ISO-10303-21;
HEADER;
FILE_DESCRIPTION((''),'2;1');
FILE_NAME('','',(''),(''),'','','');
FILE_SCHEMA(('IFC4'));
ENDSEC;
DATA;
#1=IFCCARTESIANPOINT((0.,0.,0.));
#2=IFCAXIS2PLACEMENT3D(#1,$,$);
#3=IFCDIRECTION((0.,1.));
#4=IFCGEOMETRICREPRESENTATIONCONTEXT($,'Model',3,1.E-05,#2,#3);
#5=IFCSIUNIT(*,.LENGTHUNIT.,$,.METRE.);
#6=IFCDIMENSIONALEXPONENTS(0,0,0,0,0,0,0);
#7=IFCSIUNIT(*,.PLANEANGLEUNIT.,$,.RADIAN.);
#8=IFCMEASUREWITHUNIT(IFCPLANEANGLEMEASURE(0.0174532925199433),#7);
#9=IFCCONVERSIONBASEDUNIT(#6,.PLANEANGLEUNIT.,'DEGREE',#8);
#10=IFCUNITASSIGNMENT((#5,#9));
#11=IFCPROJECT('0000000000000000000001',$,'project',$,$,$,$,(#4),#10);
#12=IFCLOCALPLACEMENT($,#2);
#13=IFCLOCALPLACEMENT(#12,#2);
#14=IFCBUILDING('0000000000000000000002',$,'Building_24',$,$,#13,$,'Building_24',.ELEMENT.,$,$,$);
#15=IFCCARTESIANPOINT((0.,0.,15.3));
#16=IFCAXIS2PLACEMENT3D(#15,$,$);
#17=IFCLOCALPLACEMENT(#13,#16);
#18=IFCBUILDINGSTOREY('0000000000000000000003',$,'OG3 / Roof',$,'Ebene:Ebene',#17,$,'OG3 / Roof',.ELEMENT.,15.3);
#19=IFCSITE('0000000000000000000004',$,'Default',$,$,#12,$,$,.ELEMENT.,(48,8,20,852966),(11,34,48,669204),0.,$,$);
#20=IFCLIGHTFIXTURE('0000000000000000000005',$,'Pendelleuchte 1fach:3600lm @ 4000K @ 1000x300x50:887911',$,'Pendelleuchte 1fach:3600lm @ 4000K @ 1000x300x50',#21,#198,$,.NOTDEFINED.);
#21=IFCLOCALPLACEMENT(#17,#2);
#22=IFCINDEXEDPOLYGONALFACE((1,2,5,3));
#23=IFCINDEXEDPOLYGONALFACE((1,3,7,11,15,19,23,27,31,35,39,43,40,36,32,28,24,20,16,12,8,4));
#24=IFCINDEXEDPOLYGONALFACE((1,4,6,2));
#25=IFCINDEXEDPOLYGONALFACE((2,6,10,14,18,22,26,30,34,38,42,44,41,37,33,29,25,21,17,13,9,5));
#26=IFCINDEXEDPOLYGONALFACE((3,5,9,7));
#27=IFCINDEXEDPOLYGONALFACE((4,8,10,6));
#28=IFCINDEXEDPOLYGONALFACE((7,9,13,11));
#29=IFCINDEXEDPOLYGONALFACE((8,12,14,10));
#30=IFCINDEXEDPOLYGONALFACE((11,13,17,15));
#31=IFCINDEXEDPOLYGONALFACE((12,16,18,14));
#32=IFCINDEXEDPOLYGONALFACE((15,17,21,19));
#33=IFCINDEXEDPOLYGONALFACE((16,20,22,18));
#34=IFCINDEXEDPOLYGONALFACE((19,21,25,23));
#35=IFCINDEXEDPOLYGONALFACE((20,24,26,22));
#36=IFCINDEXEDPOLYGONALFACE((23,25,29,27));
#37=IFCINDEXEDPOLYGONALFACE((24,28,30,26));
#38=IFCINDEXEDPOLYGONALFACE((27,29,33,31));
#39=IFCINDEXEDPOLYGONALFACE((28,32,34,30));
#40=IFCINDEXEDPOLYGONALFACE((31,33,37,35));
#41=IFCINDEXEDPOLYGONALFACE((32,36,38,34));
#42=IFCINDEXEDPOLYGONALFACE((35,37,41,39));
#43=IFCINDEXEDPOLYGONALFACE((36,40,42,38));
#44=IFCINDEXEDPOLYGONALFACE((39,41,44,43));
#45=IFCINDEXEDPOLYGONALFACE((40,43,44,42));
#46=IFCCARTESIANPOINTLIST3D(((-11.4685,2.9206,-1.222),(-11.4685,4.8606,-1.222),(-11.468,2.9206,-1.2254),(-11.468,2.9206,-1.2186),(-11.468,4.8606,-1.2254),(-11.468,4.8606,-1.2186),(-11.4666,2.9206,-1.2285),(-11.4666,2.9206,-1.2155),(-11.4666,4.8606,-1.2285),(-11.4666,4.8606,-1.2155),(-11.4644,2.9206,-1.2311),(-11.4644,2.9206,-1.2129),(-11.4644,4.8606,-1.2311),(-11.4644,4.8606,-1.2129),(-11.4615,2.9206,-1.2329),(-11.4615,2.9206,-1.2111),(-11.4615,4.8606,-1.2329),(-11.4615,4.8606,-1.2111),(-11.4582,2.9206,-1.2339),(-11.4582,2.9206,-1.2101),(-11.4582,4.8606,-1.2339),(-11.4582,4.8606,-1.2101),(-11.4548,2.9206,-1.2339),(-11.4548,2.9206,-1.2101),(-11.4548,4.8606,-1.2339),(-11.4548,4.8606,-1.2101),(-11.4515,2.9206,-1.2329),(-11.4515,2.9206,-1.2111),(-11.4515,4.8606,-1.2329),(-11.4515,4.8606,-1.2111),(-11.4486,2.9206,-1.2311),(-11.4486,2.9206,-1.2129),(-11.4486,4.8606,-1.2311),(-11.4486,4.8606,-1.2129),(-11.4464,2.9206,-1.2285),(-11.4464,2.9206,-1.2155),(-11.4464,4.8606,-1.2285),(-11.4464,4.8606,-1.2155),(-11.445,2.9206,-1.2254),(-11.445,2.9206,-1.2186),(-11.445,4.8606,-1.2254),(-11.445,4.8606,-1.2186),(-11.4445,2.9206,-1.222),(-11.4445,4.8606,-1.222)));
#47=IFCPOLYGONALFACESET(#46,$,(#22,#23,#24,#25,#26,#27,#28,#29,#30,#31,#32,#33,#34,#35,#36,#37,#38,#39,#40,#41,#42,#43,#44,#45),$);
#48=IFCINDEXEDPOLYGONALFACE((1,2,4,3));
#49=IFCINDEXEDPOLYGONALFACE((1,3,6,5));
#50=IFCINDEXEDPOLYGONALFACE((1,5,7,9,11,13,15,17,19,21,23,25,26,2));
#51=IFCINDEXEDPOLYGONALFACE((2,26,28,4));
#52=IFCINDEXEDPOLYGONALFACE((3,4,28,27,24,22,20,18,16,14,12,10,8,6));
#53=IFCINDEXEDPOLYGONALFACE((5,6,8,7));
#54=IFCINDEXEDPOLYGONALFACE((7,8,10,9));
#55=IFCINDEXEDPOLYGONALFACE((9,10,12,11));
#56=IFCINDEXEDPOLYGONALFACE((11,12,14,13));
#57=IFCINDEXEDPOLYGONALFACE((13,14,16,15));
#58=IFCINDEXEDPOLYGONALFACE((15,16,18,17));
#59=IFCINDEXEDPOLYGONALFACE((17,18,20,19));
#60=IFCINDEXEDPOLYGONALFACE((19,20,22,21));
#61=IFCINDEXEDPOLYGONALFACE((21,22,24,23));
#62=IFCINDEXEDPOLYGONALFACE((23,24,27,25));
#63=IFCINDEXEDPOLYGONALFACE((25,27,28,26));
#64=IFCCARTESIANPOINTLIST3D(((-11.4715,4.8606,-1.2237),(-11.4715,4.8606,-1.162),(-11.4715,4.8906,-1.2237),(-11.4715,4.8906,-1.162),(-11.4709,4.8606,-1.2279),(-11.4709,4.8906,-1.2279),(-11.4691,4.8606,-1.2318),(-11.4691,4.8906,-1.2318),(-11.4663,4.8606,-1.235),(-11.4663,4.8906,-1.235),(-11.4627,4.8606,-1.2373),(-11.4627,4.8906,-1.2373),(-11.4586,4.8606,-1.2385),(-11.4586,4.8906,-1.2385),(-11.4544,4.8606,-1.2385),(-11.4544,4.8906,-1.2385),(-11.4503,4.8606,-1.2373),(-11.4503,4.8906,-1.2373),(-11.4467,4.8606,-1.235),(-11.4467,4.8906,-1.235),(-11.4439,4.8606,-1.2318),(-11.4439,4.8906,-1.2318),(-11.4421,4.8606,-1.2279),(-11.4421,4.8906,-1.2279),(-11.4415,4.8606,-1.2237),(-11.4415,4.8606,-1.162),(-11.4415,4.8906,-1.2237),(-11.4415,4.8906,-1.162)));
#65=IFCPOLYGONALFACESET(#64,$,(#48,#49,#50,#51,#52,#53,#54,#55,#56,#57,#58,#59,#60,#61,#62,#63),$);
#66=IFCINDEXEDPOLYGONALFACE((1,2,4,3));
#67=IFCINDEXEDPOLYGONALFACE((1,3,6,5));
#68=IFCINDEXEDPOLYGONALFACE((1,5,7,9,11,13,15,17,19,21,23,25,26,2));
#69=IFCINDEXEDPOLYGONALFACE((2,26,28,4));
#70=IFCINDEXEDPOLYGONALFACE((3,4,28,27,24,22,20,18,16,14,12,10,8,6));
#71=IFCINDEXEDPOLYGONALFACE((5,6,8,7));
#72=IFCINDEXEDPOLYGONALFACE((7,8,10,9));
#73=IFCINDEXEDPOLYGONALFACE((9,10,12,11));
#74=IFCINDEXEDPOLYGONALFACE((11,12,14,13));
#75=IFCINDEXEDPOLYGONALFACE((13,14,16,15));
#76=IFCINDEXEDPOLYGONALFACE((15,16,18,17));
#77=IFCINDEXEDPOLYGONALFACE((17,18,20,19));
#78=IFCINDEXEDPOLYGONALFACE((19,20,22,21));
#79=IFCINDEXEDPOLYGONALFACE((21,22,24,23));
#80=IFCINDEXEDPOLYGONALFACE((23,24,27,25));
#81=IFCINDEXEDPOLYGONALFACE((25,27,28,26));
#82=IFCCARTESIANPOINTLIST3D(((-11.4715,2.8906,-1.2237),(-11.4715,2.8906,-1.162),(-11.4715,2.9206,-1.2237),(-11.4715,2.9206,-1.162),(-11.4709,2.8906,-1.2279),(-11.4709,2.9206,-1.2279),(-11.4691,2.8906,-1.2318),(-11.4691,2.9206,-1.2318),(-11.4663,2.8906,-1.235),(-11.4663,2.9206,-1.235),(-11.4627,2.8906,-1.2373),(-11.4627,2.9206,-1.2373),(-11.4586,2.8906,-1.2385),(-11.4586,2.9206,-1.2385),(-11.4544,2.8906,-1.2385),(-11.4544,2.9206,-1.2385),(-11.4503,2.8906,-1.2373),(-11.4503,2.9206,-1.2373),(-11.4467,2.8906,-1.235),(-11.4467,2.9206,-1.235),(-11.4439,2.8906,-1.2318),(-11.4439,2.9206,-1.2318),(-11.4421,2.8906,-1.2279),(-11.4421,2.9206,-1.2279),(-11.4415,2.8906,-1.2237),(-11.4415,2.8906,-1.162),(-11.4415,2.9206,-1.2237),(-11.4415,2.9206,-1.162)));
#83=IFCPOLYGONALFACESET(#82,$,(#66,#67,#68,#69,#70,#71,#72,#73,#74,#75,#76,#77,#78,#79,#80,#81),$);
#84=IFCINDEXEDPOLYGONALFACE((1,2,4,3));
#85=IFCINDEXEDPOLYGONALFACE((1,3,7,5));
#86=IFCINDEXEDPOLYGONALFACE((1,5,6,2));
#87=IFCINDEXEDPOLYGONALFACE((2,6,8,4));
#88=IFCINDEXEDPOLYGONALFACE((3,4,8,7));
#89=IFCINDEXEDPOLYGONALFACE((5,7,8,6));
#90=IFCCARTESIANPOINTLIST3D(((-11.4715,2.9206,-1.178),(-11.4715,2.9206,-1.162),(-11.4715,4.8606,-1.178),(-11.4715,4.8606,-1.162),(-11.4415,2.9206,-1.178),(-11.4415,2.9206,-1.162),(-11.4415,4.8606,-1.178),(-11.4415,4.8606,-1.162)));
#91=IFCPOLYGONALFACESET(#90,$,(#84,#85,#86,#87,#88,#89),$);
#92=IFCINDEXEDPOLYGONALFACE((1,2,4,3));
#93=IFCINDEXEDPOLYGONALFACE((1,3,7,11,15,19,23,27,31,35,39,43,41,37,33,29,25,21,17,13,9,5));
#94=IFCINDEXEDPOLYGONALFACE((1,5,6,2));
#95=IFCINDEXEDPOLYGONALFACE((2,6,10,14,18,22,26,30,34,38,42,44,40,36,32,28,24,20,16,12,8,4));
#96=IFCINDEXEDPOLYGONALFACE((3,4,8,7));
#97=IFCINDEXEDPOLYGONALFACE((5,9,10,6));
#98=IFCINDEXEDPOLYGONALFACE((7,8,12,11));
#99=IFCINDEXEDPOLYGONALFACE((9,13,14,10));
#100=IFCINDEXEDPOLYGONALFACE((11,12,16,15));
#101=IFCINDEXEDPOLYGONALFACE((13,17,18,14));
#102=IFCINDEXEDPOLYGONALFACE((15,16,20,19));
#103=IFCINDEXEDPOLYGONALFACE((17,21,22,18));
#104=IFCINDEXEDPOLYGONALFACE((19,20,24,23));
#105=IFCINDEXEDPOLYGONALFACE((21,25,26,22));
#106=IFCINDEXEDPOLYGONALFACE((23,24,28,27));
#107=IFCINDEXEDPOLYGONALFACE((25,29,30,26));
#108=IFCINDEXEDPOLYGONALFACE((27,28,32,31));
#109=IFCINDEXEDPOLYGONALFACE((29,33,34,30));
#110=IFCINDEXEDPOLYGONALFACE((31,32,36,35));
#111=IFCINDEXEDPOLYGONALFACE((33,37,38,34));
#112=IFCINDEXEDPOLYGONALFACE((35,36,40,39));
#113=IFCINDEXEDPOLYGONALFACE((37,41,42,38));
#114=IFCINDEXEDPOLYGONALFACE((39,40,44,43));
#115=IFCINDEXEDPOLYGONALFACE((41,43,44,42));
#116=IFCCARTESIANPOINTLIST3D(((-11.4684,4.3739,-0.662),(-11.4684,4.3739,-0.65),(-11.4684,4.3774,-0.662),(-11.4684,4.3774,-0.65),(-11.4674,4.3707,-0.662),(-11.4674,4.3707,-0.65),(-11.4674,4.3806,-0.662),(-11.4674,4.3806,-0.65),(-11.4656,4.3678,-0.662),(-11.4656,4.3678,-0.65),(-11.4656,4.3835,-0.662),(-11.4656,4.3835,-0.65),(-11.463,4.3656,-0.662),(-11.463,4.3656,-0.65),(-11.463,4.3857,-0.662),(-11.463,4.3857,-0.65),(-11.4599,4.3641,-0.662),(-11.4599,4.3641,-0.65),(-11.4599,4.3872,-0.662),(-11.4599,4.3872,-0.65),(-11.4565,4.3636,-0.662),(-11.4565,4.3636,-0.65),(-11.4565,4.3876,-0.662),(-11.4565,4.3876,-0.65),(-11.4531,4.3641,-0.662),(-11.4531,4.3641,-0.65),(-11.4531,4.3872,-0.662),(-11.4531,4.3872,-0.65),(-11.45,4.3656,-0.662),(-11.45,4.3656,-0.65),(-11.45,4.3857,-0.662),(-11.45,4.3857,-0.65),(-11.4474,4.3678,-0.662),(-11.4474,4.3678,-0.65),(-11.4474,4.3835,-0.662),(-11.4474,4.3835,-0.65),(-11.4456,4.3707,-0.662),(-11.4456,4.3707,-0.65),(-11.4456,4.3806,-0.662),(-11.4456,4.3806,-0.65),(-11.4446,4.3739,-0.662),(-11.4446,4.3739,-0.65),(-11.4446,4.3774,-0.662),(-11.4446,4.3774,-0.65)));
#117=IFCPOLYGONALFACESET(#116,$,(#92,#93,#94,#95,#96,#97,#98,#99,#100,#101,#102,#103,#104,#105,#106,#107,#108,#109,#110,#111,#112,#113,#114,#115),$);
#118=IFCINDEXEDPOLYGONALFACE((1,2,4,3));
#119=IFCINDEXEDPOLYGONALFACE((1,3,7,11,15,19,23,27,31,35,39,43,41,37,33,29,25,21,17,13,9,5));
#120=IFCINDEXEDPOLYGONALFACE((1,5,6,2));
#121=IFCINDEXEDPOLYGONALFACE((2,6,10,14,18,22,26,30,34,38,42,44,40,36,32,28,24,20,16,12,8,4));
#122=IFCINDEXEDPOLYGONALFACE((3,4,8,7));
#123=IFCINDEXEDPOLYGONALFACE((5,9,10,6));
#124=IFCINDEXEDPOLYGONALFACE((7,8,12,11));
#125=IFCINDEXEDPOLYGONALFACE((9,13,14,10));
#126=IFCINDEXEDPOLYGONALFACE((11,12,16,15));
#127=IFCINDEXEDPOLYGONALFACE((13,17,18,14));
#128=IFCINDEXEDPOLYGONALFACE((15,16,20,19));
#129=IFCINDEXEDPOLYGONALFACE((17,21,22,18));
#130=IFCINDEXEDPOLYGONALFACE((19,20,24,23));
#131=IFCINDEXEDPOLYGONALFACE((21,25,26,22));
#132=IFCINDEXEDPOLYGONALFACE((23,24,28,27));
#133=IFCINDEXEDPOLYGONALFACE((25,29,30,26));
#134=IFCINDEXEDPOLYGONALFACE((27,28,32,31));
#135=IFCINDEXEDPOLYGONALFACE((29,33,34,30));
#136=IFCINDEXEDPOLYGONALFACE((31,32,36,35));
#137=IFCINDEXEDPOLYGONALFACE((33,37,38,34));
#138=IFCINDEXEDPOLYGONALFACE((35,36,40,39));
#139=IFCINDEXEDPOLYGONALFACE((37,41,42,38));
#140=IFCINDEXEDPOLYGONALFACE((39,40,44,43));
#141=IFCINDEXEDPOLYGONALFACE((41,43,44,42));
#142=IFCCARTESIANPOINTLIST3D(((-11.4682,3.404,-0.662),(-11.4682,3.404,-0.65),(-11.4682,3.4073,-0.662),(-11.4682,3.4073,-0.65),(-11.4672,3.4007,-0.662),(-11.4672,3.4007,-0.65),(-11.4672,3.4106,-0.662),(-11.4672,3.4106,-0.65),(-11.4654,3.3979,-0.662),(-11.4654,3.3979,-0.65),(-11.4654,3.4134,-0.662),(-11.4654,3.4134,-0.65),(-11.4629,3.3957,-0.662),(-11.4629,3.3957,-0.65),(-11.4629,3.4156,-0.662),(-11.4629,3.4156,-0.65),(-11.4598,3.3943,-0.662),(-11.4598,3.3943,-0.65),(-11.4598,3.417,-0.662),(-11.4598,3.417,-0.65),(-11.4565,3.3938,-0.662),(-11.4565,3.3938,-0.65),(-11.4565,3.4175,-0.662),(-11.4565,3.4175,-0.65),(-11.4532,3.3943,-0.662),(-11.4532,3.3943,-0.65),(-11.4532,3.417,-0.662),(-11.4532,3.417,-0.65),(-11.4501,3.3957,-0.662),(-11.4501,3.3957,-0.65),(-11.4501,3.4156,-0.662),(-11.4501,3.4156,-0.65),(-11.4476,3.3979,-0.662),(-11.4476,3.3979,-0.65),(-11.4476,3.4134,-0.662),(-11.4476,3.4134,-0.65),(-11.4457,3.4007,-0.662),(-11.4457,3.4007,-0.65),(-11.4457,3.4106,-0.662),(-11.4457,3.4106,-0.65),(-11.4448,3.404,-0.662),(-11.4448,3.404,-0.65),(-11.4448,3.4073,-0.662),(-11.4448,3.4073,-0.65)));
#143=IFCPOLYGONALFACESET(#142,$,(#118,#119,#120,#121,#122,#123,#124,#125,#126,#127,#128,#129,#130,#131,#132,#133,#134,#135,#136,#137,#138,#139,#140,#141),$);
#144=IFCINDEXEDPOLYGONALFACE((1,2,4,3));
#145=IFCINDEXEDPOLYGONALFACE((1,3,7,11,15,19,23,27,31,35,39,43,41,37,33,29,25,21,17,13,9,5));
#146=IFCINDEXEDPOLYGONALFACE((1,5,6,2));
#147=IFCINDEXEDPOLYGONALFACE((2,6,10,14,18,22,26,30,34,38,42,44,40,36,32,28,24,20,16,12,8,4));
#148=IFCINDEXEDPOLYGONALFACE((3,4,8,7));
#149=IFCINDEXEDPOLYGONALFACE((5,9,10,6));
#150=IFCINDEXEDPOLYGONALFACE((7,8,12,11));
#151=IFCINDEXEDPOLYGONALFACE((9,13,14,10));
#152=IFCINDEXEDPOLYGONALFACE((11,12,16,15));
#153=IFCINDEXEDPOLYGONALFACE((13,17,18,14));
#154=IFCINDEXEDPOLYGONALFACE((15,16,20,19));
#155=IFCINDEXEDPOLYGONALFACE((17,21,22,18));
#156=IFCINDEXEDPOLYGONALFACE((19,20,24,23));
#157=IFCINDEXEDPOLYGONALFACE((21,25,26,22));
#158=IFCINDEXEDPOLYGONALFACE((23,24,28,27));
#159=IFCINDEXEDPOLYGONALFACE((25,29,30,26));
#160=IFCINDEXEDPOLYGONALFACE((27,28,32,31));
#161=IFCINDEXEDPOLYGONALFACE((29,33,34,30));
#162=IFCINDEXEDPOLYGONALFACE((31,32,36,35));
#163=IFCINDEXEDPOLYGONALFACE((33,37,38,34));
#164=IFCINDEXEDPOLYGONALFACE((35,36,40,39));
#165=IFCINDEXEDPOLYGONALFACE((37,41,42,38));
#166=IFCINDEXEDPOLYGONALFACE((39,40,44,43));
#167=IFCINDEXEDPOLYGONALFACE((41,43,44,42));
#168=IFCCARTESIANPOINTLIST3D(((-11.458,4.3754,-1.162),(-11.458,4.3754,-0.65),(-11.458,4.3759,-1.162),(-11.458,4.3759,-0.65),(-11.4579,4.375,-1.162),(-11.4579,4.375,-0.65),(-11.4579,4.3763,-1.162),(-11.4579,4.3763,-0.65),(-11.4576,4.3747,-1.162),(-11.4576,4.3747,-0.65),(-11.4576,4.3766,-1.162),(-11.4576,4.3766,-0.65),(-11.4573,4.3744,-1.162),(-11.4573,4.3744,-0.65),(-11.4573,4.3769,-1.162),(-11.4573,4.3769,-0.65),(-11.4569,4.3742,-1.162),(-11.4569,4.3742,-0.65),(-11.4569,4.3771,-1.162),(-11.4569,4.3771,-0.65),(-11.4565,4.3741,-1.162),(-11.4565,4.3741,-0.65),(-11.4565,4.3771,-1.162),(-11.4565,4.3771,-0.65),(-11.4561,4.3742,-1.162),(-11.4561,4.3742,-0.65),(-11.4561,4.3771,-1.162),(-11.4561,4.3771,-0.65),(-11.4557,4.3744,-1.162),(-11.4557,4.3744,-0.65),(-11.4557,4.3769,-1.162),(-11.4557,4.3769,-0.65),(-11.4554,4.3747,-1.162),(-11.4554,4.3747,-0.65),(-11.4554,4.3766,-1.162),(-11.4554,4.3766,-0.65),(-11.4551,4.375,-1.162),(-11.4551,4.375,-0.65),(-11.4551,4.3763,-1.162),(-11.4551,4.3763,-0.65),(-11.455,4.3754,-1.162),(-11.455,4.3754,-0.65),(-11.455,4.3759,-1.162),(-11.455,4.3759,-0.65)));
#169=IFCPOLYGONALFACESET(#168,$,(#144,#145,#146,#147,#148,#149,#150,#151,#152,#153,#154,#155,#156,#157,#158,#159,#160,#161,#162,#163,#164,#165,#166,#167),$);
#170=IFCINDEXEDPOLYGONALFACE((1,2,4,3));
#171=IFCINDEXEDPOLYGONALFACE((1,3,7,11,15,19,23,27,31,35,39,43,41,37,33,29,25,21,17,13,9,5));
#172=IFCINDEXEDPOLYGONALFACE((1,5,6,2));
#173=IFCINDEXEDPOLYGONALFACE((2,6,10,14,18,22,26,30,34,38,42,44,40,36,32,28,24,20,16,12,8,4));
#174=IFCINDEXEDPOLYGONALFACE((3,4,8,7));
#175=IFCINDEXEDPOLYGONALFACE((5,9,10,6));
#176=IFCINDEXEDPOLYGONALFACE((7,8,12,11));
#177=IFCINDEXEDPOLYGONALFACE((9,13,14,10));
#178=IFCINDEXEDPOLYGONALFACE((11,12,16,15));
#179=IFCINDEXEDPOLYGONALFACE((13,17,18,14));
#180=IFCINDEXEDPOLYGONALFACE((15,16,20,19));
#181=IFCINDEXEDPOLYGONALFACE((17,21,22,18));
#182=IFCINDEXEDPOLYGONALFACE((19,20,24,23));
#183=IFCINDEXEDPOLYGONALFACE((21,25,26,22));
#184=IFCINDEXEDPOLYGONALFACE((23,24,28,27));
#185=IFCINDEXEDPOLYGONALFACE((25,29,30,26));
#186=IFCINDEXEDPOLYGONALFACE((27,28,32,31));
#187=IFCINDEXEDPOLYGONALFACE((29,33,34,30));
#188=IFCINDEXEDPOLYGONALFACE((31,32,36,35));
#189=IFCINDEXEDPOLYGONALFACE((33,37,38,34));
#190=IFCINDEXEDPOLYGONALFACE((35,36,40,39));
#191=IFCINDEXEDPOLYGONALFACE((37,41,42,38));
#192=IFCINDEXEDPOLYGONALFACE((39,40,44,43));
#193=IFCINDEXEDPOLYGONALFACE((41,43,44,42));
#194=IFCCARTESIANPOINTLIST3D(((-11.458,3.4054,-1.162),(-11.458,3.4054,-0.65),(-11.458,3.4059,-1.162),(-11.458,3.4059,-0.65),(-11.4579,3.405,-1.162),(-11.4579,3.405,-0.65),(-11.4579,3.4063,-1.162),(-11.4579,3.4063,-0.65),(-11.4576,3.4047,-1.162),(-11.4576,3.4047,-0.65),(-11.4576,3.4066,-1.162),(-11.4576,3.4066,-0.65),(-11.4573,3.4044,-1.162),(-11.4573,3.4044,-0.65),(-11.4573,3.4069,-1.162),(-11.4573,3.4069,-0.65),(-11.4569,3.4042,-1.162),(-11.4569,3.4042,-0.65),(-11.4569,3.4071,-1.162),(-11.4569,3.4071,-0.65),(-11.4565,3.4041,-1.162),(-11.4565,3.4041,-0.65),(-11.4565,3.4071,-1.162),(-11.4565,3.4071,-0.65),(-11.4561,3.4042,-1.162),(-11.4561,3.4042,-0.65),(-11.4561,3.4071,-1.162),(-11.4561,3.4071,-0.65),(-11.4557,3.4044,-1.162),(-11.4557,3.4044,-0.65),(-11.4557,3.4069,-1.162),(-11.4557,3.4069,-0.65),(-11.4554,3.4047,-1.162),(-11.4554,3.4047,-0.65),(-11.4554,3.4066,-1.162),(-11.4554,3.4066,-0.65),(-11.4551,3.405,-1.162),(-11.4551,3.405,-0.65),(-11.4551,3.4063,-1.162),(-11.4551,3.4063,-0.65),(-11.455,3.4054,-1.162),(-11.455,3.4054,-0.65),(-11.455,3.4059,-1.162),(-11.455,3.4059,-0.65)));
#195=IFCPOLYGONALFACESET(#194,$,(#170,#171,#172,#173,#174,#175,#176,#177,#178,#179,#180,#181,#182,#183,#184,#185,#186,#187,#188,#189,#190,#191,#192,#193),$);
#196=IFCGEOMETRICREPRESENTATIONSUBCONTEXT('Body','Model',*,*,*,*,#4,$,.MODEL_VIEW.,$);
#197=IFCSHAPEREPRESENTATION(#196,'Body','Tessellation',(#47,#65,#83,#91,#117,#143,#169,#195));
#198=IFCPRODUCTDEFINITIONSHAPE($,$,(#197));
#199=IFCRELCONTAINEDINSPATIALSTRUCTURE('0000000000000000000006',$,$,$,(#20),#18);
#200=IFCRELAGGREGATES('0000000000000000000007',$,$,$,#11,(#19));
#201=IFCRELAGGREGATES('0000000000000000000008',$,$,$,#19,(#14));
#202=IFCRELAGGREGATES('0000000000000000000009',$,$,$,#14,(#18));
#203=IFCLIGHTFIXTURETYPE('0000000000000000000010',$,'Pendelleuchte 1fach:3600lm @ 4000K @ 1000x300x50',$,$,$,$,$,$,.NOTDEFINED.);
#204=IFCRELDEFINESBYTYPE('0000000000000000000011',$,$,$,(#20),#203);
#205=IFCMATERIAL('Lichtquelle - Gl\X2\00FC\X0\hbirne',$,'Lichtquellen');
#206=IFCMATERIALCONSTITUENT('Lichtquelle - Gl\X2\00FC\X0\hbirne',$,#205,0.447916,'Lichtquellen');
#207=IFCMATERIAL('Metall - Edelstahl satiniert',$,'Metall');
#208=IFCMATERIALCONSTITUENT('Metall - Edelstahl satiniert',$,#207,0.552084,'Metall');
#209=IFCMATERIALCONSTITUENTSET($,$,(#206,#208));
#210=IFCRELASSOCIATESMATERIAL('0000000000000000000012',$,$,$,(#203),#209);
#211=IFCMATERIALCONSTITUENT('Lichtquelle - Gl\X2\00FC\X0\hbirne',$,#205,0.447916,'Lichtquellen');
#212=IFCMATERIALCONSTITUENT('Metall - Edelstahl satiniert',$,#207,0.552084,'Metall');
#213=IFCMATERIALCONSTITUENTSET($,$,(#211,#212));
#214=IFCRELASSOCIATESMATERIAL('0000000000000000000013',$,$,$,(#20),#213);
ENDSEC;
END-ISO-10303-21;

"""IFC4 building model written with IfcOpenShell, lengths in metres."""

from ifc_helpers import new_model, entity, si_unit, converted_unit, direction, frame, origin, place, context, subcontext, project, spatial, line, arc, indexed_curve, outline, extrude, source, transform, mapped, material, constituent, constituent_set, type_object, type_shapes, element, save


model = new_model("IFC4")

# Units and contexts
model_context = context("Model", 3, precision=1e-05, world=origin(), true_north=direction((0.0, 1.0)))
body_context = subcontext(model_context, "Body", "Model", "MODEL_VIEW")
ifc_project = project(units=[si_unit("LENGTHUNIT", "METRE"), converted_unit("PLANEANGLEUNIT", "DEGREE", entity("IfcPlaneAngleMeasure", 0.0174532925199433), si_unit("PLANEANGLEUNIT", "RADIAN"), dimensions=[0, 0, 0, 0, 0, 0, 0])], contexts=[model_context])

# Site, building, storey
site_placement = place(None, origin())
site = spatial("IfcSite", under=ifc_project, at=site_placement, Name="Default", CompositionType="ELEMENT", RefLatitude=(48, 8, 20, 852966), RefLongitude=(11, 34, 48, 669204), RefElevation=0.0)
building_placement = place(site_placement, origin())
building = spatial("IfcBuilding", under=site, at=building_placement, Name="Building_24", LongName="Building_24", CompositionType="ELEMENT")
storey_placement = place(building_placement, frame((0.0, 0.0, 15.3)))
storey = spatial("IfcBuildingStorey", under=building, at=storey_placement, Name="OG3 / Roof", ObjectType="Ebene:Ebene", LongName="OG3 / Roof", CompositionType="ELEMENT", Elevation=15.3)

# Light fixture
ifc_material_1 = material(Name="Lichtquelle - Glühbirne", Category="Lichtquellen")
ifc_material_2 = material(Name="Metall - Edelstahl satiniert", Category="Metall")
ifc_constituent_1 = constituent(ifc_material_1, Name="Lichtquelle - Glühbirne", Category="Lichtquellen", fraction=0.447916)
ifc_constituent_2 = constituent(ifc_material_2, Name="Metall - Edelstahl satiniert", Category="Metall", fraction=0.552084)
ifc_constituent_set_1 = constituent_set(constituents=[ifc_constituent_1, ifc_constituent_2])
light_fixture_type_1 = type_object("IfcLightFixtureType", Name="Pendelleuchte 1fach:3600lm @ 4000K @ 1000x300x50", PredefinedType="NOTDEFINED", material=ifc_constituent_set_1)
shared_shape_1 = source(origin(), body_context, "Body", "SweptSolid", [
    extrude(outline(indexed_curve([(-0.012, 0.0), (0.0, -0.012), (0.012, 0.0), (0.0, 0.012)], segments=[arc(1, 2, 3), arc(3, 4, 1)], self_intersect=False)), frame((-0.97, 0.0, -0.572), z_axis=(1.0, 0.0, 0.0), x_axis=(0.0, 1.0, 0.0)), (0.0, 0.0, 1.0), 1.94),
    extrude(outline(indexed_curve([(-0.0308, -0.015), (0.0308, -0.015), (0.0308, 0.015), (-0.0308, 0.015), (-0.0458, 0.0)], segments=[line(1, 2, 3, 4), arc(4, 5, 1)], self_intersect=False)), frame((0.97, 0.0, -0.5428), z_axis=(1.0, 0.0, 0.0), x_axis=(0.0, 0.0, 1.0)), (0.0, 0.0, 1.0), 0.03),
    extrude(outline(indexed_curve([(-0.0308, -0.015), (0.0308, -0.015), (0.0308, 0.015), (-0.0308, 0.015), (-0.0458, 0.0)], segments=[line(1, 2, 3, 4), arc(4, 5, 1)], self_intersect=False)), frame((-1.0, 0.0, -0.5428), z_axis=(1.0, 0.0, 0.0), x_axis=(0.0, 0.0, 1.0)), (0.0, 0.0, 1.0), 0.03),
    extrude(outline(indexed_curve([(-0.97, -0.015), (0.97, -0.015), (0.97, 0.015), (-0.97, 0.015), (-0.97, -0.015)], self_intersect=False)), frame((0.0, 0.0, -0.528), z_axis=(0.0, 0.0, 1.0), x_axis=(-1.0, 0.0, 0.0)), (0.0, 0.0, 1.0), 0.016),
    extrude(outline(indexed_curve([(-0.012, 0.0), (0.0, -0.012), (0.012, 0.0), (0.0, 0.012)], segments=[arc(1, 2, 3), arc(3, 4, 1)], self_intersect=False)), frame((0.485, 0.0, -0.012)), (0.0, 0.0, 1.0), 0.012),
    extrude(outline(indexed_curve([(-0.0118, 0.0), (0.0, -0.0118), (0.0118, 0.0), (0.0, 0.0118)], segments=[arc(1, 2, 3), arc(3, 4, 1)], self_intersect=False)), frame((-0.485, 0.0, -0.012)), (0.0, 0.0, 1.0), 0.012),
    extrude(outline(indexed_curve([(-0.0015, 0.0), (0.0, -0.0015), (0.0015, 0.0), (0.0, 0.0015)], segments=[arc(1, 2, 3), arc(3, 4, 1)], self_intersect=False)), frame((0.485, 0.0, -0.512)), (0.0, 0.0, 1.0), 0.512),
    extrude(outline(indexed_curve([(-0.0015, 0.0), (0.0, -0.0015), (0.0015, 0.0), (0.0, 0.0015)], segments=[arc(1, 2, 3), arc(3, 4, 1)], self_intersect=False)), frame((-0.485, 0.0, -0.512)), (0.0, 0.0, 1.0), 0.512),
])
type_shapes(light_fixture_type_1, [shared_shape_1])
ifc_constituent_3 = constituent(ifc_material_1, Name="Lichtquelle - Glühbirne", Category="Lichtquellen", fraction=0.447916)
ifc_constituent_4 = constituent(ifc_material_2, Name="Metall - Edelstahl satiniert", Category="Metall", fraction=0.552084)
ifc_constituent_set_2 = constituent_set(constituents=[ifc_constituent_3, ifc_constituent_4])
light_fixture_1_placement = place(storey_placement, frame((-11.4565, 3.8906, -0.65), z_axis=(0.0, 0.0, 1.0), x_axis=(0.0, 1.0, 0.0)))
element("IfcLightFixture", 1, at=light_fixture_1_placement, inside=storey, type_object=light_fixture_type_1, material=ifc_constituent_set_2, Name="Pendelleuchte 1fach:3600lm @ 4000K @ 1000x300x50:887911", ObjectType="Pendelleuchte 1fach:3600lm @ 4000K @ 1000x300x50", PredefinedType="NOTDEFINED", context=body_context, shape_type="MappedRepresentation", body=[
    mapped(shared_shape_1, transform((0.0, 0.0, 0.0), scale=1.0)),
])

save(model, "model.ifc")
